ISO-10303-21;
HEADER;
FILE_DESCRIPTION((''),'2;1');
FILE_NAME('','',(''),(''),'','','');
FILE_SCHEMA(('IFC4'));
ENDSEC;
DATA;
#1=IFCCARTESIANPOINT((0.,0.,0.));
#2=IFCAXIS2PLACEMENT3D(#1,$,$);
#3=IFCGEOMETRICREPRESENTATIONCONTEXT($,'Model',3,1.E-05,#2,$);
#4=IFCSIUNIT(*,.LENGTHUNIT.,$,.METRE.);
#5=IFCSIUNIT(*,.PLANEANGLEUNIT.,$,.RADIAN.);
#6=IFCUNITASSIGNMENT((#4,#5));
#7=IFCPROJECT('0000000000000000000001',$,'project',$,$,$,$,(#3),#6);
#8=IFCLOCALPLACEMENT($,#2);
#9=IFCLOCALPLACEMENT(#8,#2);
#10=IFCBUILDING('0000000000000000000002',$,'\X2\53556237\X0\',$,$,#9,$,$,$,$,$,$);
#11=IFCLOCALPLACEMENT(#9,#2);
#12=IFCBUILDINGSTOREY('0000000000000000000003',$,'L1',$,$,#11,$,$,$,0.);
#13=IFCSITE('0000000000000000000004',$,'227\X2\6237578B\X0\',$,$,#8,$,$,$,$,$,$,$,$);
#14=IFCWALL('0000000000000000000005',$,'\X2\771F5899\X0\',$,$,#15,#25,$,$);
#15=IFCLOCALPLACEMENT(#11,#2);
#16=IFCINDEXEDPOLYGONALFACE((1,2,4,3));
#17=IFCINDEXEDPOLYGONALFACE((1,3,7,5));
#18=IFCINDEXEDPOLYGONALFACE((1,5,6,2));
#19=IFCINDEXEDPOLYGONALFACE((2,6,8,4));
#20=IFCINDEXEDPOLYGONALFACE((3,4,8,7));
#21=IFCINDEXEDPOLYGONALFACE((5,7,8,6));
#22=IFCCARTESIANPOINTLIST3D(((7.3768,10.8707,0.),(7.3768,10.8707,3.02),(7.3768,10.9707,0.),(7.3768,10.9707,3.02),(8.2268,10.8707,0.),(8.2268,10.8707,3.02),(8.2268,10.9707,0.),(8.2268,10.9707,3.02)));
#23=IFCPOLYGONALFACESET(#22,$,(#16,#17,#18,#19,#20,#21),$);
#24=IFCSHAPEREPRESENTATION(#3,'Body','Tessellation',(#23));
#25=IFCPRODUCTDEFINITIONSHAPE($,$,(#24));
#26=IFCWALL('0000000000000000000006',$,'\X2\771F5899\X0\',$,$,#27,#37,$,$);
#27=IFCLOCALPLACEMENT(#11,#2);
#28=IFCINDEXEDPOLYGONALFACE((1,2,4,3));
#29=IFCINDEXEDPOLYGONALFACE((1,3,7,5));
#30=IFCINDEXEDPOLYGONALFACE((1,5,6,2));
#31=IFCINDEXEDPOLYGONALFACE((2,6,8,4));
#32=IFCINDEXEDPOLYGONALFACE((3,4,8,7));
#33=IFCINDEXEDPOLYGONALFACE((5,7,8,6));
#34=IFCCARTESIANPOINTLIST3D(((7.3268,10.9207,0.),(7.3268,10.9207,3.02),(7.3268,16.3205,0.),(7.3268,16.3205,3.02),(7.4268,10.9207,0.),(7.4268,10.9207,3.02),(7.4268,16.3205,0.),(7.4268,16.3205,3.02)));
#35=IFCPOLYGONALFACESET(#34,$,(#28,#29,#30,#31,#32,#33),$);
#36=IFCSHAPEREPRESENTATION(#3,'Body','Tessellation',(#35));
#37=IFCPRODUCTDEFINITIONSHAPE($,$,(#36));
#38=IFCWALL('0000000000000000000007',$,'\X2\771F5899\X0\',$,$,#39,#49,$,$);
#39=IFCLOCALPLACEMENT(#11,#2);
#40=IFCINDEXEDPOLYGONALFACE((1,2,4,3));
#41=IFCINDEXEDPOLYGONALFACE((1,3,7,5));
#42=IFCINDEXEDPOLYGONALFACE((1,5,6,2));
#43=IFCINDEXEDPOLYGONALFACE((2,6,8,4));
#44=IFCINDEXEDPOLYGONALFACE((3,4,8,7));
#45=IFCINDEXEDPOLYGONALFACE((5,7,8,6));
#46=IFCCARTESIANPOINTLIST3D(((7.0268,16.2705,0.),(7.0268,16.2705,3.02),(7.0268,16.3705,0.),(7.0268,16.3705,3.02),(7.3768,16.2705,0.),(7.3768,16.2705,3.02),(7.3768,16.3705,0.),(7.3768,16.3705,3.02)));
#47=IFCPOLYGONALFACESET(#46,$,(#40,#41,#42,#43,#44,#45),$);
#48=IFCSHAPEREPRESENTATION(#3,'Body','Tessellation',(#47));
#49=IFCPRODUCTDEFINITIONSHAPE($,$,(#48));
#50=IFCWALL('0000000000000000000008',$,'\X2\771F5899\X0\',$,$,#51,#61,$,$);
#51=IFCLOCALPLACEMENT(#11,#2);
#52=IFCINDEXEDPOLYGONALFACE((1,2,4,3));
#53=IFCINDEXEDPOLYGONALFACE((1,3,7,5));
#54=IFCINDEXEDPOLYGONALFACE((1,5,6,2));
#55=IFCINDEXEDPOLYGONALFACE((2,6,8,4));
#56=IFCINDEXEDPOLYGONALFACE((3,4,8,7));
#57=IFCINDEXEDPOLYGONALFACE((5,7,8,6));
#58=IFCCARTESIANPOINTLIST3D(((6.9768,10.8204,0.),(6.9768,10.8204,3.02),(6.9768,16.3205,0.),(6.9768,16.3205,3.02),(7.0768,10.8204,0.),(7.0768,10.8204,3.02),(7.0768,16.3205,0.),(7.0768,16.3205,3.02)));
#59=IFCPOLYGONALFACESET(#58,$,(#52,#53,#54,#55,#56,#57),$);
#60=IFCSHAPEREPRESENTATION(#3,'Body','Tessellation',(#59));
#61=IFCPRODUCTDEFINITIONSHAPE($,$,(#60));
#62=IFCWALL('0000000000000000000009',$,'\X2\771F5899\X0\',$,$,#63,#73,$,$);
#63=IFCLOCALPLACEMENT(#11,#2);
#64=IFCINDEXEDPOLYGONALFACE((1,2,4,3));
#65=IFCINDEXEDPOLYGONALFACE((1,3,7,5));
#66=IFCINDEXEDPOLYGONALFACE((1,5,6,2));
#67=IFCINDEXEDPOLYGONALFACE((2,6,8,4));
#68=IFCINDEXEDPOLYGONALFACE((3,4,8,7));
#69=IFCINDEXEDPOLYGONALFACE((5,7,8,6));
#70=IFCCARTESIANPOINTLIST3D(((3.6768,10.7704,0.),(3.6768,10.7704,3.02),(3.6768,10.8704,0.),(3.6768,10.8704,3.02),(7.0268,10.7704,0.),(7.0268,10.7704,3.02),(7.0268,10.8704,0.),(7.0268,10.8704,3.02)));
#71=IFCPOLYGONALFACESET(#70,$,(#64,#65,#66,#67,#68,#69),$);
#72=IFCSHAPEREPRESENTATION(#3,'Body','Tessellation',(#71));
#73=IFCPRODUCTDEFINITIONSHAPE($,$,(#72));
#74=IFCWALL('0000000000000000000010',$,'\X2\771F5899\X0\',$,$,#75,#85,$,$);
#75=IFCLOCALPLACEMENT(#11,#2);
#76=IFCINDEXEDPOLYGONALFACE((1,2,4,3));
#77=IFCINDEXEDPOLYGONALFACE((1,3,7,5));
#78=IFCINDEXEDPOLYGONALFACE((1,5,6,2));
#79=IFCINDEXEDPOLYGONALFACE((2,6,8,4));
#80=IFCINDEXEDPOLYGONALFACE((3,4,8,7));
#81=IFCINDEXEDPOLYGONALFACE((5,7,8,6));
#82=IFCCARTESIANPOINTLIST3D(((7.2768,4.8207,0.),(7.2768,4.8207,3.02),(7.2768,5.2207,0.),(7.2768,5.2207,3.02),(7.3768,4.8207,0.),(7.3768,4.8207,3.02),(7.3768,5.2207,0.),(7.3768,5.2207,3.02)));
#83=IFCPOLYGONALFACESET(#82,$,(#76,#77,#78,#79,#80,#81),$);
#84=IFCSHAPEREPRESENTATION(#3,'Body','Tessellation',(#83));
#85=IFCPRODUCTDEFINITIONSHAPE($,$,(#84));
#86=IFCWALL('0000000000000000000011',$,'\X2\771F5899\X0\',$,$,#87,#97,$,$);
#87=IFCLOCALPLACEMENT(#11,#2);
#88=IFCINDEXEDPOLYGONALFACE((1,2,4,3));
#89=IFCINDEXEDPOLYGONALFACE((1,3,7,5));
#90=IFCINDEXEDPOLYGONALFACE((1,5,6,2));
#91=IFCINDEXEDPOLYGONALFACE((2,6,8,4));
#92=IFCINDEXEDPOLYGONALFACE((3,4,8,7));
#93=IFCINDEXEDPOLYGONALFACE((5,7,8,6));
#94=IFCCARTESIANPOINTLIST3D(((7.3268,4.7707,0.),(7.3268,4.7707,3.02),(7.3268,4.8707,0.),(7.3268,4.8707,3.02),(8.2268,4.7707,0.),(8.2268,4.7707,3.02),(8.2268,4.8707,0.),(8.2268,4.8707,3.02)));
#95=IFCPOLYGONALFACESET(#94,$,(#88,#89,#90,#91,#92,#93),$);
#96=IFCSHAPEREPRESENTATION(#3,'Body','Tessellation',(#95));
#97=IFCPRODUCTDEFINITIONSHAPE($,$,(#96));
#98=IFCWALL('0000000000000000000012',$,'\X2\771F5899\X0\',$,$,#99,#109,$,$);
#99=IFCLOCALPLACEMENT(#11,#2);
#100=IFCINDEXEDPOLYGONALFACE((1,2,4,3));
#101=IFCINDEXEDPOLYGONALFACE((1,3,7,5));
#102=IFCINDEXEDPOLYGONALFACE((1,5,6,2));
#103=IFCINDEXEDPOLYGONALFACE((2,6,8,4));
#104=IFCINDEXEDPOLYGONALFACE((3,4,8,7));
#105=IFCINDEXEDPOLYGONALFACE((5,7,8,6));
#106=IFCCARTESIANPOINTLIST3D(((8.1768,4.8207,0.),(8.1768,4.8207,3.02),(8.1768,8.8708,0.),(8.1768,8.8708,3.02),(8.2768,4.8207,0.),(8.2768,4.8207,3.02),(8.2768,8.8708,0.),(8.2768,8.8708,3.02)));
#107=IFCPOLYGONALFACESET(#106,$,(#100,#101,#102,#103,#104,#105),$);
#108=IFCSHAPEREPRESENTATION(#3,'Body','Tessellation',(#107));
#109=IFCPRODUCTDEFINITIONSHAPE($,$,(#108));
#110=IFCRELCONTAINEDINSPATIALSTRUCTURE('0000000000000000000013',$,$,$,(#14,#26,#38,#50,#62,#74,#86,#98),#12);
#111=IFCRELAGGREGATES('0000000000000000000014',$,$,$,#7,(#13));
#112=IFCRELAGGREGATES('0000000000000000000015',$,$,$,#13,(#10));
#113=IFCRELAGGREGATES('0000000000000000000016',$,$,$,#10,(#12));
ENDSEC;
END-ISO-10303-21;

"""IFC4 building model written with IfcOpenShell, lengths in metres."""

from ifc_helpers import new_model, si_unit, origin, place, context, project, spatial, polyline, outline, extrude, element, save


model = new_model("IFC4")

# Units and contexts
model_context = context("Model", 3, precision=1e-05, world=origin())
ifc_project = project(units=[si_unit("LENGTHUNIT", "METRE"), si_unit("PLANEANGLEUNIT", "RADIAN")], contexts=[model_context])

# Site, building, storey
site_placement = place(None, origin())
site = spatial("IfcSite", under=ifc_project, at=site_placement, Name="227户型")
building_placement = place(site_placement, origin())
building = spatial("IfcBuilding", under=site, at=building_placement, Name="单户")
storey_placement = place(building_placement, origin())
storey = spatial("IfcBuildingStorey", under=building, at=storey_placement, Name="L1", Elevation=0.0)

# Walls
wall_1_placement = place(storey_placement, origin())
element("IfcWall", 1, at=wall_1_placement, inside=storey, Name="真墙", context=model_context, shape_type="SweptSolid", body=[
    extrude(outline(polyline([(8.2268, 10.8707), (7.3768, 10.8707), (7.3768, 10.9707), (8.2268, 10.9707), (8.2268, 10.8707)])), origin(), (0.0, 0.0, 1.0), 3.02),
])
wall_2_placement = place(storey_placement, origin())
element("IfcWall", 2, at=wall_2_placement, inside=storey, Name="真墙", context=model_context, shape_type="SweptSolid", body=[
    extrude(outline(polyline([(7.3268, 10.9207), (7.3268, 16.3205), (7.4268, 16.3205), (7.4268, 10.9207), (7.3268, 10.9207)])), origin(), (0.0, 0.0, 1.0), 3.02),
])
wall_3_placement = place(storey_placement, origin())
element("IfcWall", 3, at=wall_3_placement, inside=storey, Name="真墙", context=model_context, shape_type="SweptSolid", body=[
    extrude(outline(polyline([(7.3768, 16.2705), (7.0268, 16.2705), (7.0268, 16.3705), (7.3768, 16.3705), (7.3768, 16.2705)])), origin(), (0.0, 0.0, 1.0), 3.02),
])
wall_4_placement = place(storey_placement, origin())
element("IfcWall", 4, at=wall_4_placement, inside=storey, Name="真墙", context=model_context, shape_type="SweptSolid", body=[
    extrude(outline(polyline([(7.0768, 16.3205), (7.0768, 10.8204), (6.9768, 10.8204), (6.9768, 16.3205), (7.0768, 16.3205)])), origin(), (0.0, 0.0, 1.0), 3.02),
])
wall_5_placement = place(storey_placement, origin())
element("IfcWall", 5, at=wall_5_placement, inside=storey, Name="真墙", context=model_context, shape_type="SweptSolid", body=[
    extrude(outline(polyline([(7.0268, 10.7704), (3.6768, 10.7704), (3.6768, 10.8704), (7.0268, 10.8704), (7.0268, 10.7704)])), origin(), (0.0, 0.0, 1.0), 3.02),
])
wall_6_placement = place(storey_placement, origin())
element("IfcWall", 6, at=wall_6_placement, inside=storey, Name="真墙", context=model_context, shape_type="SweptSolid", body=[
    extrude(outline(polyline([(7.3768, 5.2207), (7.3768, 4.8207), (7.2768, 4.8207), (7.2768, 5.2207), (7.3768, 5.2207)])), origin(), (0.0, 0.0, 1.0), 3.02),
])
wall_7_placement = place(storey_placement, origin())
element("IfcWall", 7, at=wall_7_placement, inside=storey, Name="真墙", context=model_context, shape_type="SweptSolid", body=[
    extrude(outline(polyline([(7.3268, 4.8707), (8.2268, 4.8707), (8.2268, 4.7707), (7.3268, 4.7707), (7.3268, 4.8707)])), origin(), (0.0, 0.0, 1.0), 3.02),
])
wall_8_placement = place(storey_placement, origin())
element("IfcWall", 8, at=wall_8_placement, inside=storey, Name="真墙", context=model_context, shape_type="SweptSolid", body=[
    extrude(outline(polyline([(8.1768, 4.8207), (8.1768, 8.8708), (8.2768, 8.8708), (8.2768, 4.8207), (8.1768, 4.8207)])), origin(), (0.0, 0.0, 1.0), 3.02),
])

save(model, "model.ifc")
